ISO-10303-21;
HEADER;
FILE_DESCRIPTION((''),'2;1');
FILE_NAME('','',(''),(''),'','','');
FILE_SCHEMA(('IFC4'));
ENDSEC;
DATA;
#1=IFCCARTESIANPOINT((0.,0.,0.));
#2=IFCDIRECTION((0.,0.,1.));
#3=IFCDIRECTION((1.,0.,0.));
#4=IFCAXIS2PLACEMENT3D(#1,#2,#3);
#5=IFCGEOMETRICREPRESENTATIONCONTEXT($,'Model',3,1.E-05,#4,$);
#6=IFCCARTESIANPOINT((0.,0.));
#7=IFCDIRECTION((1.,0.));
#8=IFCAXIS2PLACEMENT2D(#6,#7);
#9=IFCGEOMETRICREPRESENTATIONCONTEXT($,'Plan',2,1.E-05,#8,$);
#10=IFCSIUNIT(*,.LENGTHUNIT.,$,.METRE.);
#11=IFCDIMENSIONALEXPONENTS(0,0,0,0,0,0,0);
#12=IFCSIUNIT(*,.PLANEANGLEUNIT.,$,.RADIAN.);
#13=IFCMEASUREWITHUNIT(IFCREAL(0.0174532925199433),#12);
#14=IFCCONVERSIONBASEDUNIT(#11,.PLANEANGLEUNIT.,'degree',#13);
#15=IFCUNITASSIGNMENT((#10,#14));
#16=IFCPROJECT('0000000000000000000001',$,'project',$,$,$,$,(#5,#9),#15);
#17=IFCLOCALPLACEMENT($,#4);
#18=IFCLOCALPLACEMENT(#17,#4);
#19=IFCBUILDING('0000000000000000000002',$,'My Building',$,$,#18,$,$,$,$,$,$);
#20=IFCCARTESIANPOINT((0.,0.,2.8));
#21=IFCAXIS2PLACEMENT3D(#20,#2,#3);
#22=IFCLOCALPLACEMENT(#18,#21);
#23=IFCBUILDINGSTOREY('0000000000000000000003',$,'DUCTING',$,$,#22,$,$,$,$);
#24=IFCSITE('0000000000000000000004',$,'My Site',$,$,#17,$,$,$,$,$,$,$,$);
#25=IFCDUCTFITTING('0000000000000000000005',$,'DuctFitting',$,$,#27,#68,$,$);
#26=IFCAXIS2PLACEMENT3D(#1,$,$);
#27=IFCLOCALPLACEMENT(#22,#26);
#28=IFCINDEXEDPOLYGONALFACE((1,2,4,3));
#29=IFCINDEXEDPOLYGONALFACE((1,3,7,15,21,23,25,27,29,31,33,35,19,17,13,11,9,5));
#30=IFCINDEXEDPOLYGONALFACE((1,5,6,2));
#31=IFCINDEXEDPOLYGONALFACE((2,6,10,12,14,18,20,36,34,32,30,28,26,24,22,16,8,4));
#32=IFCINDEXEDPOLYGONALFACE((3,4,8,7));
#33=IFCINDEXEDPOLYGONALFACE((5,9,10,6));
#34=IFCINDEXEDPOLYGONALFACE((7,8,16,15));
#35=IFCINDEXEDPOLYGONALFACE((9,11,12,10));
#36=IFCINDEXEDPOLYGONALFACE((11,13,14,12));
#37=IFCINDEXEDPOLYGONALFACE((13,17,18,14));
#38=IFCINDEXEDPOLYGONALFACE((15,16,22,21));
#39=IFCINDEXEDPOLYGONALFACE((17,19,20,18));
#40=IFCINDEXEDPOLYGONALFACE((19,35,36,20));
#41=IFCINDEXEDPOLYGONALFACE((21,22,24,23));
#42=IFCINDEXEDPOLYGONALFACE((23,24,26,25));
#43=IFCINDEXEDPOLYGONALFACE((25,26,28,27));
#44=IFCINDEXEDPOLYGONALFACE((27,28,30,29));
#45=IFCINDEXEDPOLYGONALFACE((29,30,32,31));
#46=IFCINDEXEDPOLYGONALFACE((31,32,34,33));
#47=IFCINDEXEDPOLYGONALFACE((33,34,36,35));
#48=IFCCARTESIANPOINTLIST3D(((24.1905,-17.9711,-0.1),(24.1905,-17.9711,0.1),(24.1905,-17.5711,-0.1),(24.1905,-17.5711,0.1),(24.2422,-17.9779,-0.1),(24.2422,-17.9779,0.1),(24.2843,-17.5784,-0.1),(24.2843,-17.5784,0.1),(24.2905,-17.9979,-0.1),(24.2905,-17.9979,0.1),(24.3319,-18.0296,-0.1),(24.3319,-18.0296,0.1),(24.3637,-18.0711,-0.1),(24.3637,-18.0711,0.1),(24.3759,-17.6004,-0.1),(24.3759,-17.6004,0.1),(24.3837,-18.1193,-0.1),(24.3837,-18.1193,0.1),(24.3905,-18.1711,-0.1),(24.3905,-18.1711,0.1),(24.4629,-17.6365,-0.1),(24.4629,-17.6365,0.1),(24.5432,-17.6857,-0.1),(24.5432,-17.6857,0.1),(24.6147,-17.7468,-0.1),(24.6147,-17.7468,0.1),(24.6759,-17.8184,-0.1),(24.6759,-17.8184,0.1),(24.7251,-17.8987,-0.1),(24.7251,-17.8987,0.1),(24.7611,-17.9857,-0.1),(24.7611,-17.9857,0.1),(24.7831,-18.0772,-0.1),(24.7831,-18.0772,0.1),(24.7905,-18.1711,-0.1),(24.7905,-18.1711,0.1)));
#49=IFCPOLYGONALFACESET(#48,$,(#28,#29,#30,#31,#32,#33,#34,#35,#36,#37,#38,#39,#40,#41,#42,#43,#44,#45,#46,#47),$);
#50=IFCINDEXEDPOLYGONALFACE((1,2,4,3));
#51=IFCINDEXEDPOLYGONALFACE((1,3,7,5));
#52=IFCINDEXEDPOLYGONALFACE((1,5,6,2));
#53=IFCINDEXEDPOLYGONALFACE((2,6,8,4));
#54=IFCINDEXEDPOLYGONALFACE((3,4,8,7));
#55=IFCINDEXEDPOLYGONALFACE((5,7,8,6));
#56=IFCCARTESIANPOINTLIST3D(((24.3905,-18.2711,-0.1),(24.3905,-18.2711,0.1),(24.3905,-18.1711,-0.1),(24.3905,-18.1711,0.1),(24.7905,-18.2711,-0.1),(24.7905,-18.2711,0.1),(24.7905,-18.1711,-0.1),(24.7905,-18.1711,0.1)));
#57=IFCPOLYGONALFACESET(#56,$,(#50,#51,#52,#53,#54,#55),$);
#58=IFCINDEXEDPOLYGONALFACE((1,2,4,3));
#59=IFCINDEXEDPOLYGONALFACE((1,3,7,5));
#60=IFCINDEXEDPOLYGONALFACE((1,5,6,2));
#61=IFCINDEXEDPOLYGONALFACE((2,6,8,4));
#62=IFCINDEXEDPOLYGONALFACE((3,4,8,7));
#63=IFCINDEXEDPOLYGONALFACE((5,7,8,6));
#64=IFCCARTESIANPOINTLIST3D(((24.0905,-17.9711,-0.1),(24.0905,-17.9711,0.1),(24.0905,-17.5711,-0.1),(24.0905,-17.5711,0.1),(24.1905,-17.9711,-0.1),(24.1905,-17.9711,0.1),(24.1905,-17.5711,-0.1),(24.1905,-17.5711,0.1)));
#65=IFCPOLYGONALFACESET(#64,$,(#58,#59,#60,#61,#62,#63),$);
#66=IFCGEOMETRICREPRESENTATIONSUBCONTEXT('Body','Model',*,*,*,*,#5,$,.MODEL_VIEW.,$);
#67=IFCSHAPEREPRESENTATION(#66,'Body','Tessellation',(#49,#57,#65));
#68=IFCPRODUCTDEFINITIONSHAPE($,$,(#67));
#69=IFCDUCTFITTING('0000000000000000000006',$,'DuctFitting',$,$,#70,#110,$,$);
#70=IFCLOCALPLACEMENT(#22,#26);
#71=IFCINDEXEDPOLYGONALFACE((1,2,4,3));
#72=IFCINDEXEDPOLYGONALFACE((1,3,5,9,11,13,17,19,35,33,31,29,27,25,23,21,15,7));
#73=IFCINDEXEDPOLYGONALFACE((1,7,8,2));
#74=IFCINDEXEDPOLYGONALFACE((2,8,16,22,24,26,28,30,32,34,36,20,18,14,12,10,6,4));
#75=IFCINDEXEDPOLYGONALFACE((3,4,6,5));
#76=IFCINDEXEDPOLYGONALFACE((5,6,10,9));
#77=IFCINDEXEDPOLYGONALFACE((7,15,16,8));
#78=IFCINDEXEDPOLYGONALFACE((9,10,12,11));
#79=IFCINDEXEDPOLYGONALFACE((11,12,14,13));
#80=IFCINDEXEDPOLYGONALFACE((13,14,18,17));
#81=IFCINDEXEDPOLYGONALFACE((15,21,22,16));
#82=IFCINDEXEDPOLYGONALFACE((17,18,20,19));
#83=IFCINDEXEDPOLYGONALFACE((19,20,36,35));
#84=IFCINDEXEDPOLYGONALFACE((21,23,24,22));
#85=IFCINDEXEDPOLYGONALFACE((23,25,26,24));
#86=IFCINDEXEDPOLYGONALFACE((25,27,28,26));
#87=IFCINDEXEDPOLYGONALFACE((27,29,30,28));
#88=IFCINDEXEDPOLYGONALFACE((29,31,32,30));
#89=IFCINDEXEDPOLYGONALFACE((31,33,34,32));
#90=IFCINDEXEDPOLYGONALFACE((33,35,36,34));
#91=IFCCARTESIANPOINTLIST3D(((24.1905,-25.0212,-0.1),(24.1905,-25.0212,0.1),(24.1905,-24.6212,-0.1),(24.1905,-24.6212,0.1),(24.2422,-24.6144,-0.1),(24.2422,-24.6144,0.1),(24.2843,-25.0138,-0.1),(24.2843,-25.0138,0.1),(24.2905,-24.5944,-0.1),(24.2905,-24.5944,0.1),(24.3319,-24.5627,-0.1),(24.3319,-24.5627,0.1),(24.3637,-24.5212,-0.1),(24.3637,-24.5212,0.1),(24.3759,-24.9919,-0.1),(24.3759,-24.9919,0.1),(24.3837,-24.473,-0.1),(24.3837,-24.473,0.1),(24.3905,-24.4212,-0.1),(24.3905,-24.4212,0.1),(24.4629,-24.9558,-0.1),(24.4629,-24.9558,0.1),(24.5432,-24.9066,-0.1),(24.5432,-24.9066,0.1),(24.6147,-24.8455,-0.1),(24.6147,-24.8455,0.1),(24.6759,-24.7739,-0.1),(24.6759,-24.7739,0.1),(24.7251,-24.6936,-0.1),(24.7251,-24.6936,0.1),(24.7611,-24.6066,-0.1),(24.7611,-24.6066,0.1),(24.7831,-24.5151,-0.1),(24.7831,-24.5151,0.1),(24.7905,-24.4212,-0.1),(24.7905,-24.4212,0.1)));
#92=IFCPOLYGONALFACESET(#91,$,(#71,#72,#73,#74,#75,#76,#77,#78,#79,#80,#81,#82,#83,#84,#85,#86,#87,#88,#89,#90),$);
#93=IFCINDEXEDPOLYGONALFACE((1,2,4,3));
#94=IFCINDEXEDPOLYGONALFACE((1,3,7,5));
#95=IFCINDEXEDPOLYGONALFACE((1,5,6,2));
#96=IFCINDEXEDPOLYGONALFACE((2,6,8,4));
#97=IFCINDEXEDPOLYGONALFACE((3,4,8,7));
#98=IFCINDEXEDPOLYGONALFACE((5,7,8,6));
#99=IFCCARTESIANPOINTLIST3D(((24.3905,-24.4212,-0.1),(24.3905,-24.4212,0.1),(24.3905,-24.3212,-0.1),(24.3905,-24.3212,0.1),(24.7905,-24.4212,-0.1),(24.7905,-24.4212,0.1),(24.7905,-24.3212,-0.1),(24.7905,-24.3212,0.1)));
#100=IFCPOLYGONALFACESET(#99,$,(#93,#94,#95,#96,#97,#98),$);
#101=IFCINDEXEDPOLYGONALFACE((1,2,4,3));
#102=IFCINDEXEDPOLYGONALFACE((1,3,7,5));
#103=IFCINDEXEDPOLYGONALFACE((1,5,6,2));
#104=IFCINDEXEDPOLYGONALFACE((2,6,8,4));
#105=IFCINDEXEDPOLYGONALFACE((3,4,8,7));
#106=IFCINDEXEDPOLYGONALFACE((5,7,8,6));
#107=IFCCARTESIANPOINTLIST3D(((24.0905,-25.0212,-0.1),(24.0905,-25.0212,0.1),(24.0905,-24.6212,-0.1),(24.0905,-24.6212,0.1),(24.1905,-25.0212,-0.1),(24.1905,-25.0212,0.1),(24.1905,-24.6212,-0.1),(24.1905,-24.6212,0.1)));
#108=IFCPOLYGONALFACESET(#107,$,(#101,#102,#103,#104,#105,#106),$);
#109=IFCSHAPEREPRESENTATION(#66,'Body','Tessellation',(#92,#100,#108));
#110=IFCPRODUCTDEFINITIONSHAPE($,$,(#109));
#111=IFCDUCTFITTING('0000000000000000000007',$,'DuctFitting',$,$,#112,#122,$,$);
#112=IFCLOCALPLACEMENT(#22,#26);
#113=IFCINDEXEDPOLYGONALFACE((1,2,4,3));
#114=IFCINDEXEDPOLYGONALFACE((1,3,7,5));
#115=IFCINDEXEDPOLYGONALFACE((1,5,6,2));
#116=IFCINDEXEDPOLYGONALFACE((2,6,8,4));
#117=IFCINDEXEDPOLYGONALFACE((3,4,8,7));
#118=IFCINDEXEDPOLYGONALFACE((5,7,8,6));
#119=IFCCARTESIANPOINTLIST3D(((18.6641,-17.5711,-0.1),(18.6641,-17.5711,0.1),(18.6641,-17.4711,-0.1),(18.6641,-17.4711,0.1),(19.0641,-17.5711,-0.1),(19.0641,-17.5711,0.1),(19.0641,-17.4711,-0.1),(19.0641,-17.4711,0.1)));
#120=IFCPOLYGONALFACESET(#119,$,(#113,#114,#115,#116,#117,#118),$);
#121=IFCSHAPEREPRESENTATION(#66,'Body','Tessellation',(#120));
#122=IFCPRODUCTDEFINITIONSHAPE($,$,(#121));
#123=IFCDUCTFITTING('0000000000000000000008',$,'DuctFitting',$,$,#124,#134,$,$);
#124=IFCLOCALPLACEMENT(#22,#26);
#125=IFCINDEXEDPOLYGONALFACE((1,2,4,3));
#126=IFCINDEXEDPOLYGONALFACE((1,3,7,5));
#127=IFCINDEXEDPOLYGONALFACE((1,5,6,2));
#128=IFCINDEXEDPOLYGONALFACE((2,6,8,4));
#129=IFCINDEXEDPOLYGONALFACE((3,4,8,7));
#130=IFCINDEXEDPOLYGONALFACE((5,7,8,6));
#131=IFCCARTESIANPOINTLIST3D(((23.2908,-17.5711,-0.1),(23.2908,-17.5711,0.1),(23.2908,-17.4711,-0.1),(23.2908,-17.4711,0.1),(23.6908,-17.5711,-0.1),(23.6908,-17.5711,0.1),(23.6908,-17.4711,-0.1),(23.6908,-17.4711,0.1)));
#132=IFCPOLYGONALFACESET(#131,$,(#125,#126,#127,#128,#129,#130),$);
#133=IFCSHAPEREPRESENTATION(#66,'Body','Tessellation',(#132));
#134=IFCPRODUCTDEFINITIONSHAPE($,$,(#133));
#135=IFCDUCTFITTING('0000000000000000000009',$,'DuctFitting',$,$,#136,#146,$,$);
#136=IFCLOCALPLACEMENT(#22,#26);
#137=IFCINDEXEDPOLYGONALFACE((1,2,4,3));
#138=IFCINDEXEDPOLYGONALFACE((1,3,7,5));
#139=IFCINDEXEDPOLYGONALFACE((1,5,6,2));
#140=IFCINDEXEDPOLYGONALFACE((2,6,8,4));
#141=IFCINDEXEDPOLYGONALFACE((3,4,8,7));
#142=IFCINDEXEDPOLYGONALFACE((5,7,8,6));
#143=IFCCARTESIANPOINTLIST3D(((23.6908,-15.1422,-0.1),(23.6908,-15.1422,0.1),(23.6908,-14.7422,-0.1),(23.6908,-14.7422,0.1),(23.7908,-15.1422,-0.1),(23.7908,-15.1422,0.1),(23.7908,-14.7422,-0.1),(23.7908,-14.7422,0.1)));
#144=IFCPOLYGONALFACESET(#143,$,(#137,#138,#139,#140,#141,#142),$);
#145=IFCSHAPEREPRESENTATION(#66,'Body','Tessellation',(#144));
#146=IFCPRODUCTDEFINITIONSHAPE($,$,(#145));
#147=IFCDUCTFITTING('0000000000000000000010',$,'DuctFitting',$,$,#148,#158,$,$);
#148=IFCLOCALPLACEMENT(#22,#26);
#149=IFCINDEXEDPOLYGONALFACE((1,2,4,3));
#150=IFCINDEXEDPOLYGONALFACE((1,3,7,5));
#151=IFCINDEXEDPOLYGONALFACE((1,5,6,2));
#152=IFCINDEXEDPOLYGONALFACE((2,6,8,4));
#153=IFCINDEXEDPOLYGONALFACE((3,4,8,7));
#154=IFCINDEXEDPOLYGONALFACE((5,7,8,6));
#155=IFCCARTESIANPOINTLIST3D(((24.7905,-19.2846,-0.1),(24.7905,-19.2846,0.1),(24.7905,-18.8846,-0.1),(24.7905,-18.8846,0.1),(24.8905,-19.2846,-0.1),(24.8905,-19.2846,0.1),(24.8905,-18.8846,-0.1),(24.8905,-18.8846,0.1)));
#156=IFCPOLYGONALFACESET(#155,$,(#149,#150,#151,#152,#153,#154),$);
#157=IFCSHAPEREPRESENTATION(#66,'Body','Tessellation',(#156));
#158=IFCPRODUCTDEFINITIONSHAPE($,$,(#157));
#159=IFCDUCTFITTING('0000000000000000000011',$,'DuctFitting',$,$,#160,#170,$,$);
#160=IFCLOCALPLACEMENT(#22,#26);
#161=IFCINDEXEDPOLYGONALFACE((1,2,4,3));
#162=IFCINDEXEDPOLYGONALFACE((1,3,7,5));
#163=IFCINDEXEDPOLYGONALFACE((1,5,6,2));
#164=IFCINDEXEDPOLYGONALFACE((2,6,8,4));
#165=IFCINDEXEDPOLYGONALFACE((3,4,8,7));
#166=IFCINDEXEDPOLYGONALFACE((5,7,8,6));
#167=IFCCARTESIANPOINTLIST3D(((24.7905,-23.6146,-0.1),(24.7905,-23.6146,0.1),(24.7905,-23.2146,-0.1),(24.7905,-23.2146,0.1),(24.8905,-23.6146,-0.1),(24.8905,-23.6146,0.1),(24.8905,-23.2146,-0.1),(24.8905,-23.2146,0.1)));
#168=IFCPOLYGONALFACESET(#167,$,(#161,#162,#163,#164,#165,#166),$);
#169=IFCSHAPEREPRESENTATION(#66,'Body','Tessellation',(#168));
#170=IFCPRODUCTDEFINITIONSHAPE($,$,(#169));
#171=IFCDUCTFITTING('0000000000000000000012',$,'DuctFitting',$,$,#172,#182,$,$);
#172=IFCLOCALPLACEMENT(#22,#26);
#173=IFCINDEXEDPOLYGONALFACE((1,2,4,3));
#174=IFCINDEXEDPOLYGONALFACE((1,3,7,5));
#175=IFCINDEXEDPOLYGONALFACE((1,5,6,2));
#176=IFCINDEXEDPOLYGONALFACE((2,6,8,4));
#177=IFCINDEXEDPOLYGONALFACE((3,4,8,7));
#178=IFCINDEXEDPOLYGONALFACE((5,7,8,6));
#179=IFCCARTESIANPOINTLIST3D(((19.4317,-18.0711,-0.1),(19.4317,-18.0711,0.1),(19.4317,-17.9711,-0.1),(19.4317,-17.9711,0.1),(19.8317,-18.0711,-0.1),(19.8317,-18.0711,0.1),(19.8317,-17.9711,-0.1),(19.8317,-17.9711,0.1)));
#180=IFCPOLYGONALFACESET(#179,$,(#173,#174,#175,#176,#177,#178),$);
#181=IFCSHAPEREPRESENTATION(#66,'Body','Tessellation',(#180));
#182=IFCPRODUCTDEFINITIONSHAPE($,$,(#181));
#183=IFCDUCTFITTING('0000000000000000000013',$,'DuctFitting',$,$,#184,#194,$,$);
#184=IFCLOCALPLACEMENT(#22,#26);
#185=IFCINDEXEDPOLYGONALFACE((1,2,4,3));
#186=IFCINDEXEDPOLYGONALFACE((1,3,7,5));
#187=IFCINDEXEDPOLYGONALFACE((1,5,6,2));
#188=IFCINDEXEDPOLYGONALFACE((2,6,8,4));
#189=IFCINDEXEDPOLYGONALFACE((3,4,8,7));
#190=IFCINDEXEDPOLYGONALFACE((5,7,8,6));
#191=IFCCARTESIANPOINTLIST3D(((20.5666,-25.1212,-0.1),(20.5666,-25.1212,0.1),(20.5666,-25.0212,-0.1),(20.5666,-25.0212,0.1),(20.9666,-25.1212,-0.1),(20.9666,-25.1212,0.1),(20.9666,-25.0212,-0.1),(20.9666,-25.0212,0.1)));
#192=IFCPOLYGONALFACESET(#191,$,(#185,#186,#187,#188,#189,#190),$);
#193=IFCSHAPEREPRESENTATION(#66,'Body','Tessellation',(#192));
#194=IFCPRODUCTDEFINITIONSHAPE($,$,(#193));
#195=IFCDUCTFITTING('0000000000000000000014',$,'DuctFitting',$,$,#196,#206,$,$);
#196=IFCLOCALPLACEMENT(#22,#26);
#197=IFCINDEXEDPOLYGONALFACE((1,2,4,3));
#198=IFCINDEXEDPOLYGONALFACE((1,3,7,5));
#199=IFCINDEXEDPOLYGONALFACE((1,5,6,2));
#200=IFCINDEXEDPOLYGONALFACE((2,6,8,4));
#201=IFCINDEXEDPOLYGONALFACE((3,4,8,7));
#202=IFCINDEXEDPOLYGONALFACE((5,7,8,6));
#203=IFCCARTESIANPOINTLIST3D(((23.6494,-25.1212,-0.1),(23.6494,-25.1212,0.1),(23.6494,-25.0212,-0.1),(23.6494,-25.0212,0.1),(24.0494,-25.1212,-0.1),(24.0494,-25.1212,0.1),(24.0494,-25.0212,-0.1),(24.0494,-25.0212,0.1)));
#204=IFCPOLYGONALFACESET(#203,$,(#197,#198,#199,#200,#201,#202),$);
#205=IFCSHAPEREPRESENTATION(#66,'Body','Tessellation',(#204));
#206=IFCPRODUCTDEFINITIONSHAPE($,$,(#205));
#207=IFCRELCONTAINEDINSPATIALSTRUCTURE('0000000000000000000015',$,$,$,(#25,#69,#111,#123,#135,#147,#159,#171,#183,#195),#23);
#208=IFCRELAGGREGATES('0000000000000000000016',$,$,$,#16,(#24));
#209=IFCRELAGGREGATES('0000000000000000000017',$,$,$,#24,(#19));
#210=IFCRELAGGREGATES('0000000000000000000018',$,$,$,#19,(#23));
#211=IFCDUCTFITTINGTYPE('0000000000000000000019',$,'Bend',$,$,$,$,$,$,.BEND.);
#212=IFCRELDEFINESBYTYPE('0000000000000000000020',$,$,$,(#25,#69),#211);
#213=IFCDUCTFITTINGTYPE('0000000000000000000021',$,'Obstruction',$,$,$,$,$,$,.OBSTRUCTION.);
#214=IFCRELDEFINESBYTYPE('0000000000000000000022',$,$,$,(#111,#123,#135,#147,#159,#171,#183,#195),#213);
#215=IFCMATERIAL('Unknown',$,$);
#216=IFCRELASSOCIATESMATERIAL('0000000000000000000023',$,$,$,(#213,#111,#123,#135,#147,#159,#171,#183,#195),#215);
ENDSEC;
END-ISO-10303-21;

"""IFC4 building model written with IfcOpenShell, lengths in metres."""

from ifc_helpers import new_model, entity, si_unit, converted_unit, frame, origin_with_axes, origin_2d_with_axis, place, context, subcontext, project, spatial, line, arc, indexed_curve, rectangle, outline, extrude, source, transform, mapped, material, material_profile, profile_set, profile_usage, type_object, type_shapes, element, save


model = new_model("IFC4")

# Units and contexts
model_context = context("Model", 3, precision=1e-05, world=origin_with_axes())
plan_context = context("Plan", 2, precision=1e-05, world=origin_2d_with_axis())
body_context = subcontext(model_context, "Body", "Model", "MODEL_VIEW")
ifc_project = project(units=[si_unit("LENGTHUNIT", "METRE"), converted_unit("PLANEANGLEUNIT", "degree", entity("IfcReal", 0.0174532925199433), si_unit("PLANEANGLEUNIT", "RADIAN"), dimensions=[0, 0, 0, 0, 0, 0, 0])], contexts=[model_context, plan_context])

# Site, building, storey
site_placement = place(None, origin_with_axes())
site = spatial("IfcSite", under=ifc_project, at=site_placement, Name="My Site")
building_placement = place(site_placement, origin_with_axes())
building = spatial("IfcBuilding", under=site, at=building_placement, Name="My Building")
storey_placement = place(building_placement, frame((0.0, 0.0, 2.8), z_axis=(0.0, 0.0, 1.0), x_axis=(1.0, 0.0, 0.0)))
storey = spatial("IfcBuildingStorey", under=building, at=storey_placement, Name="DUCTING")

# Shared definitions
ifc_material = material(Name="Unknown")

# Duct fittings
duct_fitting_type_1 = type_object("IfcDuctFittingType", Name="Bend", PredefinedType="BEND")
shared_shape = source(origin_with_axes(), body_context, "Body", "SweptSolid", [
    extrude(outline(indexed_curve([(-0.2, 0.0), (-0.2586, -0.1414), (-0.4, -0.2), (-0.4, -0.6), (0.0243, -0.4243), (0.2, 0.0)], segments=[arc(1, 2, 3), line(3, 4), arc(4, 5, 6), line(6, 1)])), frame((0.0, -0.1, -0.1), z_axis=(0.0, -1.0, 0.0), x_axis=(1.0, 0.0, 0.0)), (0.0, 0.0, -1.0), 0.2),
    extrude(rectangle(XDim=0.4, YDim=0.2), origin_with_axes(), (0.0, 0.0, -1.0), 0.1),
    extrude(rectangle(XDim=0.4, YDim=0.2), frame((-0.4, 0.0, -0.5), z_axis=(-1.0, 0.0, 0.0), x_axis=(0.0, 0.0, -1.0)), (0.0, 0.0, 1.0), 0.1),
])
type_shapes(duct_fitting_type_1, [shared_shape])
for number, where, z_axis, x_axis, name in (
    (1, (24.5905, -18.2711, 0.0), (0.0, -1.0, 0.0), (1.0, 0.0, 0.0), "DuctFitting"),
    (2, (24.5905, -24.3212, 0.0), (0.0, 1.0, 0.0), (1.0, 0.0, 0.0), "DuctFitting"),
):
    element("IfcDuctFitting", number, at=place(storey_placement, frame(where, z_axis=z_axis, x_axis=x_axis)), inside=storey, type_object=duct_fitting_type_1, Name=name, context=body_context, shape_type="MappedRepresentation", body=[
        mapped(shared_shape, transform((0.0, 0.0, 0.0), x_axis=(1.0, 0.0, 0.0), y_axis=(0.0, 1.0, 0.0), z_axis=(0.0, 0.0, 1.0), scale=1.0)),
    ])
ifc_material_profile_1 = material_profile(ifc_material, rectangle(XDim=0.4, YDim=0.2))
ifc_profile_set_1 = profile_set([ifc_material_profile_1])
ifc_profile_usage_1 = profile_usage(ifc_profile_set_1, cardinal=5)
duct_fitting_type_2 = type_object("IfcDuctFittingType", Name="Obstruction", PredefinedType="OBSTRUCTION", material=ifc_profile_set_1)
duct_fitting_1_placement = place(storey_placement, frame((18.8641, -17.4711, 0.0), z_axis=(0.0, -1.0, 0.0), x_axis=(1.0, 0.0, 0.0)))
element("IfcDuctFitting", 3, at=duct_fitting_1_placement, inside=storey, type_object=duct_fitting_type_2, material=ifc_profile_usage_1, Name="DuctFitting", context=body_context, shape_type="SweptSolid", body=[
    extrude(rectangle(XDim=0.4, YDim=0.2), origin_with_axes(), (0.0, 0.0, 1.0), 0.1),
])
ifc_profile_usage_2 = profile_usage(ifc_profile_set_1, cardinal=5)
duct_fitting_2_placement = place(storey_placement, frame((23.4908, -17.4711, 0.0), z_axis=(0.0, -1.0, 0.0), x_axis=(1.0, 0.0, 0.0)))
element("IfcDuctFitting", 4, at=duct_fitting_2_placement, inside=storey, type_object=duct_fitting_type_2, material=ifc_profile_usage_2, Name="DuctFitting", context=body_context, shape_type="SweptSolid", body=[
    extrude(rectangle(XDim=0.4, YDim=0.2), origin_with_axes(), (0.0, 0.0, 1.0), 0.1),
])
ifc_profile_usage_3 = profile_usage(ifc_profile_set_1, cardinal=5)
duct_fitting_3_placement = place(storey_placement, frame((23.7908, -14.9422, 0.0), z_axis=(-1.0, 0.0, 0.0), x_axis=(0.0, -1.0, 0.0)))
element("IfcDuctFitting", 5, at=duct_fitting_3_placement, inside=storey, type_object=duct_fitting_type_2, material=ifc_profile_usage_3, Name="DuctFitting", context=body_context, shape_type="SweptSolid", body=[
    extrude(rectangle(XDim=0.4, YDim=0.2), origin_with_axes(), (0.0, 0.0, 1.0), 0.1),
])
ifc_profile_usage_4 = profile_usage(ifc_profile_set_1, cardinal=5)
duct_fitting_4_placement = place(storey_placement, frame((24.8905, -19.0846, 0.0), z_axis=(-1.0, 0.0, 0.0), x_axis=(0.0, -1.0, 0.0)))
element("IfcDuctFitting", 6, at=duct_fitting_4_placement, inside=storey, type_object=duct_fitting_type_2, material=ifc_profile_usage_4, Name="DuctFitting", context=body_context, shape_type="SweptSolid", body=[
    extrude(rectangle(XDim=0.4, YDim=0.2), origin_with_axes(), (0.0, 0.0, 1.0), 0.1),
])
ifc_profile_usage_5 = profile_usage(ifc_profile_set_1, cardinal=5)
duct_fitting_5_placement = place(storey_placement, frame((24.8905, -23.4146, 0.0), z_axis=(-1.0, 0.0, 0.0), x_axis=(0.0, -1.0, 0.0)))
element("IfcDuctFitting", 7, at=duct_fitting_5_placement, inside=storey, type_object=duct_fitting_type_2, material=ifc_profile_usage_5, Name="DuctFitting", context=body_context, shape_type="SweptSolid", body=[
    extrude(rectangle(XDim=0.4, YDim=0.2), origin_with_axes(), (0.0, 0.0, 1.0), 0.1),
])
ifc_profile_usage_6 = profile_usage(ifc_profile_set_1, cardinal=5)
duct_fitting_6_placement = place(storey_placement, frame((19.6317, -18.0711, 0.0), z_axis=(0.0, 1.0, 0.0), x_axis=(-1.0, 0.0, 0.0)))
element("IfcDuctFitting", 8, at=duct_fitting_6_placement, inside=storey, type_object=duct_fitting_type_2, material=ifc_profile_usage_6, Name="DuctFitting", context=body_context, shape_type="SweptSolid", body=[
    extrude(rectangle(XDim=0.4, YDim=0.2), origin_with_axes(), (0.0, 0.0, 1.0), 0.1),
])
ifc_profile_usage_7 = profile_usage(ifc_profile_set_1, cardinal=5)
duct_fitting_7_placement = place(storey_placement, frame((20.7666, -25.1212, 0.0), z_axis=(0.0, 1.0, 0.0), x_axis=(-1.0, 0.0, 0.0)))
element("IfcDuctFitting", 9, at=duct_fitting_7_placement, inside=storey, type_object=duct_fitting_type_2, material=ifc_profile_usage_7, Name="DuctFitting", context=body_context, shape_type="SweptSolid", body=[
    extrude(rectangle(XDim=0.4, YDim=0.2), origin_with_axes(), (0.0, 0.0, 1.0), 0.1),
])
ifc_profile_usage_8 = profile_usage(ifc_profile_set_1, cardinal=5)
duct_fitting_8_placement = place(storey_placement, frame((23.8494, -25.1212, 0.0), z_axis=(0.0, 1.0, 0.0), x_axis=(-1.0, 0.0, 0.0)))
element("IfcDuctFitting", 10, at=duct_fitting_8_placement, inside=storey, type_object=duct_fitting_type_2, material=ifc_profile_usage_8, Name="DuctFitting", context=body_context, shape_type="SweptSolid", body=[
    extrude(rectangle(XDim=0.4, YDim=0.2), origin_with_axes(), (0.0, 0.0, 1.0), 0.1),
])

save(model, "model.ifc")
